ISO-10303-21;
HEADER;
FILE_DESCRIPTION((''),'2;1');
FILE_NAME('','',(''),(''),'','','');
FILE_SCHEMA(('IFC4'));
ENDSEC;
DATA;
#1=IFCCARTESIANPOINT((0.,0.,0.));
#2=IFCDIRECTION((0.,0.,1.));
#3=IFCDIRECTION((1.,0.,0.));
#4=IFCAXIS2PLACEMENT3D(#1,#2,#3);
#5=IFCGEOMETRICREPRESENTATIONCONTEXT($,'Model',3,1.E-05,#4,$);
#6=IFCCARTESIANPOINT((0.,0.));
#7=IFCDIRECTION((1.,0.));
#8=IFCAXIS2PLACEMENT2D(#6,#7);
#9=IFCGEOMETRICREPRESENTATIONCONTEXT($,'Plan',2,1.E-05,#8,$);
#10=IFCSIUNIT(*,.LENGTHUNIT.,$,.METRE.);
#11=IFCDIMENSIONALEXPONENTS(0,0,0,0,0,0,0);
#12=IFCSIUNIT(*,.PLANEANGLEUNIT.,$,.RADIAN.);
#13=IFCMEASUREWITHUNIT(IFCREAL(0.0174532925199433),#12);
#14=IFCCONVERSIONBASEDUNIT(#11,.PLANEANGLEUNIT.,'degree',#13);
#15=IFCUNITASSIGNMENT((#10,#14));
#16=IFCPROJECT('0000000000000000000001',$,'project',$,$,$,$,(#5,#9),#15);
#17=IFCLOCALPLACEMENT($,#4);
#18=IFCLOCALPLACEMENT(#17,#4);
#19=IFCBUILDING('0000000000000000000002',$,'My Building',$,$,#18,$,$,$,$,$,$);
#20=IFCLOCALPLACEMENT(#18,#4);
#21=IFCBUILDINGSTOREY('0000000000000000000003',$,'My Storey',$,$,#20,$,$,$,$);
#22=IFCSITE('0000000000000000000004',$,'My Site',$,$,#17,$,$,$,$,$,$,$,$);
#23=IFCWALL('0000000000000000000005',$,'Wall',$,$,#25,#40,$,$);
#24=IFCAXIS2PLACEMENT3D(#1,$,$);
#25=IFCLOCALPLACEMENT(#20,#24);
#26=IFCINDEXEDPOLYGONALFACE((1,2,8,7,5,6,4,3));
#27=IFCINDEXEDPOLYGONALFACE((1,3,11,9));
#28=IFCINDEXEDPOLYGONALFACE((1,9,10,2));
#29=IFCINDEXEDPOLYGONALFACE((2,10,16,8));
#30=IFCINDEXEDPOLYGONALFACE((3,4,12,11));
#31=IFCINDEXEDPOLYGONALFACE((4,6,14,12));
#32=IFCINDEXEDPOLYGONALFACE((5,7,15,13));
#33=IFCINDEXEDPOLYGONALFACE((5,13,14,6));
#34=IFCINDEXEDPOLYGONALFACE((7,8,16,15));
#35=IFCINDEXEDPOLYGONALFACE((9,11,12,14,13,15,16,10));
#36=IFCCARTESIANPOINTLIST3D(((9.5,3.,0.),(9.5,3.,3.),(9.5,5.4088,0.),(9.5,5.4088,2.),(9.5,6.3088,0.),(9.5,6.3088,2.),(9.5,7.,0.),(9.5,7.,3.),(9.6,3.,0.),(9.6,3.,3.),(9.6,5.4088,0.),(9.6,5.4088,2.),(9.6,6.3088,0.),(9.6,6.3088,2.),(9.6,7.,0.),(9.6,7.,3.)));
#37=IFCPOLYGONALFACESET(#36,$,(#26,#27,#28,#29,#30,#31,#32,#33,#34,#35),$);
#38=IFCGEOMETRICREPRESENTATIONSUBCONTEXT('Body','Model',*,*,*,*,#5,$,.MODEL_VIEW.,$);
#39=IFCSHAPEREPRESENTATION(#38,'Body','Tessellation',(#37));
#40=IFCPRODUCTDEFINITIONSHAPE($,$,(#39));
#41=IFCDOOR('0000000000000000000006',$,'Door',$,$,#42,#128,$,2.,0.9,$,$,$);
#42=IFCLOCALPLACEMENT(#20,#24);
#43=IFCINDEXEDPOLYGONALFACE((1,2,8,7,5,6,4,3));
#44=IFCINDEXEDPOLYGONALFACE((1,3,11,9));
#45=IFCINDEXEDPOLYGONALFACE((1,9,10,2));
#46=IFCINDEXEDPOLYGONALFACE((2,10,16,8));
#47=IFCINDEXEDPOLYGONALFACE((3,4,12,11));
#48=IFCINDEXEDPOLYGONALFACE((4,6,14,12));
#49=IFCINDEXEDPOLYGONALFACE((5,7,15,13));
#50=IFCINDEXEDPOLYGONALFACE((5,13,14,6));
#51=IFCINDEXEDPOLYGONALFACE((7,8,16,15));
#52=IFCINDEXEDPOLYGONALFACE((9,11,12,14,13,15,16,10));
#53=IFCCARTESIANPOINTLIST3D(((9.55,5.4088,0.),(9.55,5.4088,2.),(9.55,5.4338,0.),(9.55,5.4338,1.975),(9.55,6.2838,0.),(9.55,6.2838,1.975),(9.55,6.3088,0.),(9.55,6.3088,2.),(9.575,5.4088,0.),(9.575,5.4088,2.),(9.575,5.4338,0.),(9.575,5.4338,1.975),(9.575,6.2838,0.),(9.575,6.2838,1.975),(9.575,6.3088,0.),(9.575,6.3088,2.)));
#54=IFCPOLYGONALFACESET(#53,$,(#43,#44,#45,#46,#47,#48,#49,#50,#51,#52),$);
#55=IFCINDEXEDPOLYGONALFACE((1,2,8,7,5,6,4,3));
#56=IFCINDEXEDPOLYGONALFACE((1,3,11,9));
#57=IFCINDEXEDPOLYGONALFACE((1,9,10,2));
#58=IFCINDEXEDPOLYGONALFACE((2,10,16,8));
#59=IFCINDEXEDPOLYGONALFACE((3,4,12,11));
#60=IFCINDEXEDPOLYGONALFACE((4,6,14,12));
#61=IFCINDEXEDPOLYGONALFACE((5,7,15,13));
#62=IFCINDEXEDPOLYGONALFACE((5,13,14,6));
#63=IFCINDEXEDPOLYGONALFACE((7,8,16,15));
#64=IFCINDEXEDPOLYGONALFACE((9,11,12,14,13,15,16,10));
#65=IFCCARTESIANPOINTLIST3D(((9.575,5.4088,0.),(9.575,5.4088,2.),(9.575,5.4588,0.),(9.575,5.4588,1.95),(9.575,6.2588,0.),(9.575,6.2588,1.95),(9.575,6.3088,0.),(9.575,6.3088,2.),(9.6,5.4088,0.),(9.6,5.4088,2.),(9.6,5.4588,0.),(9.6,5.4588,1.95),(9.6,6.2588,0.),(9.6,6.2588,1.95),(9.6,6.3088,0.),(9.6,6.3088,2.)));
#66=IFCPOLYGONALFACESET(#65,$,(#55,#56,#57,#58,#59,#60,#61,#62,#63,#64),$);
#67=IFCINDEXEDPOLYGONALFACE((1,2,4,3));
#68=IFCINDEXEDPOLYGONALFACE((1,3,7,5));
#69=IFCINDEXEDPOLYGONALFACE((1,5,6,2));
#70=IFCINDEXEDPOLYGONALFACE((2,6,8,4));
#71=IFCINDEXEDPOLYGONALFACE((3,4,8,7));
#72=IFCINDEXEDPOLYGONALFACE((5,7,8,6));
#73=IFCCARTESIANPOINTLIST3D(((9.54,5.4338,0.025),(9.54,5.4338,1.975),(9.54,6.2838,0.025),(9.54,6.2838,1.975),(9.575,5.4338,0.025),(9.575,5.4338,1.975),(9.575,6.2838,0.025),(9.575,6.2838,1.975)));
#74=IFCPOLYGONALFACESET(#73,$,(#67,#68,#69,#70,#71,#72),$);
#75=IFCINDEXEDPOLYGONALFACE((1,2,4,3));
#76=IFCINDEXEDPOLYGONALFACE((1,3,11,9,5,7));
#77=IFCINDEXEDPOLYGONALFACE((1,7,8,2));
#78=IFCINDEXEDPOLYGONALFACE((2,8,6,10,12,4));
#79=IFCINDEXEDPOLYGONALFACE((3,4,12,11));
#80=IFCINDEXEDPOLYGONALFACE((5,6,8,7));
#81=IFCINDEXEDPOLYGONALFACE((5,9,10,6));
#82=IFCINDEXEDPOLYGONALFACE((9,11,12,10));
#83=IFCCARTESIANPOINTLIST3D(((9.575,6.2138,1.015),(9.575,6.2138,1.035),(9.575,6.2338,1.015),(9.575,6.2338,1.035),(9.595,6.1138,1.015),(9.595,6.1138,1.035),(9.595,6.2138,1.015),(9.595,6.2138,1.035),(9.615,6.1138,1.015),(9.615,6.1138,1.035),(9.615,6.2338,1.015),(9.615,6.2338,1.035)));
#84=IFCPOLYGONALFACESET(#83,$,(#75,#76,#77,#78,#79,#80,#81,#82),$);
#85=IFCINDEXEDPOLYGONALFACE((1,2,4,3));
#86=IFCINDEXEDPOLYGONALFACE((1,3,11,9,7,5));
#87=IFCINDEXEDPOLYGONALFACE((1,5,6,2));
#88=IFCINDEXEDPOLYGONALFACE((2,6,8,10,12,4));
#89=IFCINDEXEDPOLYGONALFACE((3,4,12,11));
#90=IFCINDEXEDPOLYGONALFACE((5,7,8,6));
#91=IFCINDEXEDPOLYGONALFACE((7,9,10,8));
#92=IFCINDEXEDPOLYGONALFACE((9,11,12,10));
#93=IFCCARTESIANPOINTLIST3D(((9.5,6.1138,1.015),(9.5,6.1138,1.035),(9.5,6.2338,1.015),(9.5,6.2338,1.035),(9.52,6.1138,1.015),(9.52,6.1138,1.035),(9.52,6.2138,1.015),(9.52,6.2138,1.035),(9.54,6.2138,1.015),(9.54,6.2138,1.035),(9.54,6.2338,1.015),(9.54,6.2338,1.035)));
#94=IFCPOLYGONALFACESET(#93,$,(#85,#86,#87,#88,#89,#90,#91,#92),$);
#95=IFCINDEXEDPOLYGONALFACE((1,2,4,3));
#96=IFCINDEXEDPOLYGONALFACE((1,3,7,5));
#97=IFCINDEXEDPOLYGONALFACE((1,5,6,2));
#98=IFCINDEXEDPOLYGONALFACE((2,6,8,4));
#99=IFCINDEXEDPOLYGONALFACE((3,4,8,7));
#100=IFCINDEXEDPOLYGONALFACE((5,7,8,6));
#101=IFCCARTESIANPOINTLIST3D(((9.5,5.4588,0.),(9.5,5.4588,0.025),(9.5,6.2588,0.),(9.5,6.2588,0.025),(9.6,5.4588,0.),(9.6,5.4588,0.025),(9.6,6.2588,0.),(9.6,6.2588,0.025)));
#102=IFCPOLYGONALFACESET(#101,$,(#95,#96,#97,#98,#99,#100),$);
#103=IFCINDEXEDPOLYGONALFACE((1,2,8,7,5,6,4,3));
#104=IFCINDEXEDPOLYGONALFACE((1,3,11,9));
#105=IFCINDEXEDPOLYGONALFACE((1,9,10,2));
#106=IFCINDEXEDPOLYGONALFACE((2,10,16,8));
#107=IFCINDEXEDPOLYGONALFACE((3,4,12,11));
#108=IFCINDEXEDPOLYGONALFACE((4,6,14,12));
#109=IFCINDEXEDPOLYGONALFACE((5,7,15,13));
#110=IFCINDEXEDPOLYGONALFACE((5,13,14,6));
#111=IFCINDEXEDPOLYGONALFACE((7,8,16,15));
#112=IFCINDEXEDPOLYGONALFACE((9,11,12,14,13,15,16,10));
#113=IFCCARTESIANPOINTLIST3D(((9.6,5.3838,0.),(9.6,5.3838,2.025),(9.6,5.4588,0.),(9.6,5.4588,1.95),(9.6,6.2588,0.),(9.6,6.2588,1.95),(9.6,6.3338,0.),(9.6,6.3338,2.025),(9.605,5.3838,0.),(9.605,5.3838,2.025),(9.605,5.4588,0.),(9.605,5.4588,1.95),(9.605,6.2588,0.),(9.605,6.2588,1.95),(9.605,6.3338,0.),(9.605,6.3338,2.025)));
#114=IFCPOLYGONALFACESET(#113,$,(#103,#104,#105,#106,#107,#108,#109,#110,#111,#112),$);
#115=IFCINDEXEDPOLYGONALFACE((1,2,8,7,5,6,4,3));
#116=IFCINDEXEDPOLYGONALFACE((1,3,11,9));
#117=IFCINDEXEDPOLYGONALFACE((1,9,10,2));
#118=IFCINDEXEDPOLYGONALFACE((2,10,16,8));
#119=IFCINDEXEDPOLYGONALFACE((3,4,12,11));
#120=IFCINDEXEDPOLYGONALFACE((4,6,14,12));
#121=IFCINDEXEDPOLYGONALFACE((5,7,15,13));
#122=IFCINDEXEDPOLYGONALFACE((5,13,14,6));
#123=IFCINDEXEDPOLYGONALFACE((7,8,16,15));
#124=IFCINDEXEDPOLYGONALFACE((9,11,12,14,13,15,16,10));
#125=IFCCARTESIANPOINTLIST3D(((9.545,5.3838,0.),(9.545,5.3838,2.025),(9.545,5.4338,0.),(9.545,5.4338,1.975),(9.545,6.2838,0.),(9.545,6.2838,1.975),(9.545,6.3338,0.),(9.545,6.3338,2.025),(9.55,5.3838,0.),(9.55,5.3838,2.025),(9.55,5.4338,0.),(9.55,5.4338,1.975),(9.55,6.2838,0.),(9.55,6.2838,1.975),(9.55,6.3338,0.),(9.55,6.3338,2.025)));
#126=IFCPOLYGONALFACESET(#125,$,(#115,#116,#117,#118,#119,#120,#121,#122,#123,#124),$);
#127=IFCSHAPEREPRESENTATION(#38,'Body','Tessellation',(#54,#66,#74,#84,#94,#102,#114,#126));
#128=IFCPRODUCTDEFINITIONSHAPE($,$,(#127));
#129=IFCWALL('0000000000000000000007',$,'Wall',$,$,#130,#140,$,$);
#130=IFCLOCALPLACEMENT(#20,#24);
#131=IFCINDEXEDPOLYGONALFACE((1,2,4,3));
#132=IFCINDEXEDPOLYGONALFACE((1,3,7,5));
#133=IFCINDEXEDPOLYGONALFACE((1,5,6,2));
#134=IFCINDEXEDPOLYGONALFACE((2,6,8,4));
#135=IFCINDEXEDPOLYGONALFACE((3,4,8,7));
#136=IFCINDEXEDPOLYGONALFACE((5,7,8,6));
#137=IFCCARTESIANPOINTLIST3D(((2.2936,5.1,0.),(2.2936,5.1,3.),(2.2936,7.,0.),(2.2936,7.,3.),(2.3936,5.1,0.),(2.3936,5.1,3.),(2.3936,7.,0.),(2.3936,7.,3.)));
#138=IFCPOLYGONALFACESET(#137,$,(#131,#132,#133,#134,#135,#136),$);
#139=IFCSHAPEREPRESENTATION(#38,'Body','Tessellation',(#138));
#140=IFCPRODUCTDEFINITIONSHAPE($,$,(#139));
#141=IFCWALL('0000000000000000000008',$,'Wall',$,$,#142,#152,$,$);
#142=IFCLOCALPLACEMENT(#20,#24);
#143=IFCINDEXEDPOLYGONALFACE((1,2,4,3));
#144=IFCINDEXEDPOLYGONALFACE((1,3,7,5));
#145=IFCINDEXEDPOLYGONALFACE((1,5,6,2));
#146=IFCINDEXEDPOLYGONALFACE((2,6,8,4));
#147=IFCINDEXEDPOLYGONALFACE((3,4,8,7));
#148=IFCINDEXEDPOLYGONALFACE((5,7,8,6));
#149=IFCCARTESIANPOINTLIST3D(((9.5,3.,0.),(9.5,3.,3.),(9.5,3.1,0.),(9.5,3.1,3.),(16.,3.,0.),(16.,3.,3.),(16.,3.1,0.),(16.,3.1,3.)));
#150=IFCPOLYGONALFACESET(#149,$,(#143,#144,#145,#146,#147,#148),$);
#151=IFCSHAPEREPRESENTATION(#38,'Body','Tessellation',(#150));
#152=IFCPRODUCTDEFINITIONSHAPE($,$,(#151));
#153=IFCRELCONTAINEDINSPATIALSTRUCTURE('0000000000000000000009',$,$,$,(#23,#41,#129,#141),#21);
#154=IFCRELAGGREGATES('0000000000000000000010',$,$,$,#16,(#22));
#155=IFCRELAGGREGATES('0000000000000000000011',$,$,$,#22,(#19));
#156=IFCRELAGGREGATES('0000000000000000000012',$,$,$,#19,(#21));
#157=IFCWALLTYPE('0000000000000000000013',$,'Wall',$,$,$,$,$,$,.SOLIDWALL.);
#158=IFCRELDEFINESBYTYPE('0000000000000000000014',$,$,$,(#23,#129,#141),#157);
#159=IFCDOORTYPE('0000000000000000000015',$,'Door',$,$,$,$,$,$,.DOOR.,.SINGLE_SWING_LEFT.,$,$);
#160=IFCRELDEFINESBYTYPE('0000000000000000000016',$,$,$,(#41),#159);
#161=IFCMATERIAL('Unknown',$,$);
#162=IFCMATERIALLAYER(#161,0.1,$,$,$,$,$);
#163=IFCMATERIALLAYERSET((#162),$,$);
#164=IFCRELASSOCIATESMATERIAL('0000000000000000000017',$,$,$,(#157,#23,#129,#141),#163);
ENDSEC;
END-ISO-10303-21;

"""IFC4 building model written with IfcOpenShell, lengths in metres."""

from ifc_helpers import new_model, entity, si_unit, converted_unit, frame, origin_with_axes, origin_2d_with_axis, place, context, subcontext, project, spatial, line, indexed_curve, outline, extrude, shape, source, transform, mapped, material, layer, layer_set, layer_usage, type_object, type_shapes, element, fill, save


model = new_model("IFC4")

# Units and contexts
model_context = context("Model", 3, precision=1e-05, world=origin_with_axes())
plan_context = context("Plan", 2, precision=1e-05, world=origin_2d_with_axis())
body_context_1 = subcontext(model_context, "Body", "Model", "MODEL_VIEW")
body_context_2 = subcontext(plan_context, "Body", "Plan", "PLAN_VIEW")
ifc_project = project(units=[si_unit("LENGTHUNIT", "METRE"), converted_unit("PLANEANGLEUNIT", "degree", entity("IfcReal", 0.0174532925199433), si_unit("PLANEANGLEUNIT", "RADIAN"), dimensions=[0, 0, 0, 0, 0, 0, 0])], contexts=[model_context, plan_context])

# Site, building, storey
site_placement = place(None, origin_with_axes())
site = spatial("IfcSite", under=ifc_project, at=site_placement, Name="My Site")
building_placement = place(site_placement, origin_with_axes())
building = spatial("IfcBuilding", under=site, at=building_placement, Name="My Building")
storey_placement = place(building_placement, origin_with_axes())
storey = spatial("IfcBuildingStorey", under=building, at=storey_placement, Name="My Storey")

# Shared definitions
ifc_material = material(Name="Unknown")

# Shared definitions
ifc_layer_1 = layer(ifc_material, 0.1)
ifc_layer_set_1 = layer_set([ifc_layer_1])
wall_type = type_object("IfcWallType", Name="Wall", PredefinedType="SOLIDWALL", material=ifc_layer_set_1)
shared_shape_1 = source(origin_with_axes(), body_context_1, "Body", "SweptSolid", [
    extrude(outline(indexed_curve([(0.0, 0.0), (0.9, 0.0), (0.9, 2.0), (0.0, 2.0)], segments=[line(1, 2, 3, 4, 1)])), frame((0.0, -0.6, 0.0), z_axis=(0.0, -1.0, 0.0), x_axis=(1.0, 0.0, 0.0)), (0.0, 0.0, -1.0), 1.2),
])
door_type = type_object("IfcDoorType", Name="Door", OperationType="SINGLE_SWING_LEFT", PredefinedType="DOOR")
shared_shape_2 = source(origin_with_axes(), body_context_1, "Body", "SweptSolid", [
    extrude(outline(indexed_curve([(0.0, 0.0), (0.0, 2.0), (0.9, 2.0), (0.9, 0.0), (0.875, 0.0), (0.875, 1.975), (0.025, 1.975), (0.025, 0.0)], segments=[line(1, 2, 3, 4, 5, 6, 7, 8, 1)])), frame((0.0, 0.025, 0.0), z_axis=(0.0, -1.0, 0.0), x_axis=(1.0, 0.0, 0.0)), (0.0, 0.0, -1.0), 0.025),
    extrude(outline(indexed_curve([(0.0, 0.0), (0.0, 2.0), (0.9, 2.0), (0.9, 0.0), (0.85, 0.0), (0.85, 1.95), (0.05, 1.95), (0.05, 0.0)], segments=[line(1, 2, 3, 4, 5, 6, 7, 8, 1)])), frame((0.0, 0.0, 0.0), z_axis=(0.0, -1.0, 0.0), x_axis=(1.0, 0.0, 0.0)), (0.0, 0.0, -1.0), 0.025),
    extrude(outline(indexed_curve([(0.0, 0.0), (0.85, 0.0), (0.85, 0.035), (0.0, 0.035)], segments=[line(1, 2, 3, 4, 1)])), frame((0.025, 0.025, 0.025), z_axis=(0.0, 0.0, 1.0), x_axis=(1.0, 0.0, 0.0)), (0.0, 0.0, 1.0), 1.95),
    extrude(outline(indexed_curve([(0.0, 0.0), (0.0, -0.04), (-0.12, -0.04), (-0.12, -0.02), (-0.02, -0.02), (-0.02, 0.0)], segments=[line(1, 2, 3, 4, 5, 6, 1)])), frame((0.825, 0.025, 1.015), z_axis=(0.0, 0.0, 1.0), x_axis=(1.0, 0.0, 0.0)), (0.0, 0.0, 1.0), 0.02),
    extrude(outline(indexed_curve([(0.0, 0.0), (0.0, 0.04), (-0.12, 0.04), (-0.12, 0.02), (-0.02, 0.02), (-0.02, 0.0)], segments=[line(1, 2, 3, 4, 5, 6, 1)])), frame((0.825, 0.06, 1.015), z_axis=(0.0, 0.0, 1.0), x_axis=(1.0, 0.0, 0.0)), (0.0, 0.0, 1.0), 0.02),
    extrude(outline(indexed_curve([(0.0, 0.0), (0.8, 0.0), (0.8, 0.1), (0.0, 0.1)], segments=[line(1, 2, 3, 4, 1)])), frame((0.05, 0.0, 0.0), z_axis=(0.0, 0.0, 1.0), x_axis=(1.0, 0.0, 0.0)), (0.0, 0.0, 1.0), 0.025),
    extrude(outline(indexed_curve([(0.0, 0.0), (0.0, 2.025), (0.95, 2.025), (0.95, 0.0), (0.875, 0.0), (0.875, 1.95), (0.075, 1.95), (0.075, 0.0)], segments=[line(1, 2, 3, 4, 5, 6, 7, 8, 1)])), frame((-0.025, -0.005, 0.0), z_axis=(0.0, -1.0, 0.0), x_axis=(1.0, 0.0, 0.0)), (0.0, 0.0, -1.0), 0.005),
    extrude(outline(indexed_curve([(0.0, 0.0), (0.0, 2.025), (0.95, 2.025), (0.95, 0.0), (0.9, 0.0), (0.9, 1.975), (0.05, 1.975), (0.05, 0.0)], segments=[line(1, 2, 3, 4, 5, 6, 7, 8, 1)])), frame((-0.025, 0.05, 0.0), z_axis=(0.0, -1.0, 0.0), x_axis=(1.0, 0.0, 0.0)), (0.0, 0.0, -1.0), 0.005),
])
shared_shape_3 = source(origin_with_axes(), body_context_2, "Body", "Curve2D", [
    entity("IfcIndexedPolyCurve", entity("IfcCartesianPointList2D", [[0.0, 0.0], [0.0, 0.05], [0.025, 0.05], [0.025, 0.025], [0.05, 0.025], [0.05, 0.0]]), [entity("IfcLineIndex", [1, 2, 3, 4, 5, 6, 1])]),
    entity("IfcIndexedPolyCurve", entity("IfcCartesianPointList2D", [[0.9, 0.0], [0.9, 0.05], [0.875, 0.05], [0.875, 0.025], [0.85, 0.025], [0.85, 0.0]]), [entity("IfcLineIndex", [1, 2, 3, 4, 5, 6, 1])]),
    entity("IfcTrimmedCurve", entity("IfcEllipse", entity("IfcAxis2Placement2D", entity("IfcCartesianPoint", [0.06, 0.05]), entity("IfcDirection", [1.0, 0.0])), 0.815, 0.85), [entity("IfcCartesianPoint", [0.875, 0.05])], [entity("IfcCartesianPoint", [0.06, 0.9])], True, "CARTESIAN"),
    entity("IfcIndexedPolyCurve", entity("IfcCartesianPointList2D", [[0.025, 0.05], [0.06, 0.05], [0.06, 0.9], [0.025, 0.9]]), [entity("IfcLineIndex", [1, 2, 3, 4, 1])]),
])
type_shapes(door_type, [shared_shape_2, shared_shape_3])

# Wall, opening, door
ifc_layer_usage_1 = layer_usage(ifc_layer_set_1, "AXIS2", "POSITIVE", 0.0)
wall_1_placement = place(storey_placement, frame((9.6, 3.0, 0.0), z_axis=(0.0, 0.0, 1.0), x_axis=(0.0, 1.0, 0.0)))
wall_1 = element("IfcWall", 1, at=wall_1_placement, inside=storey, type_object=wall_type, material=ifc_layer_usage_1, Name="Wall", context=body_context_1, shape_type="SweptSolid", body=[
    extrude(outline(indexed_curve([(0.0, 0.0), (0.0, 0.1), (4.0, 0.1), (4.0, 0.0)], segments=[line(1, 2, 3, 4, 1)])), origin_with_axes(), (0.0, 0.0, 1.0), 3.0),
])
opening_1_placement = place(wall_1_placement, frame((2.4088, 0.0, 0.0), z_axis=(0.0, 0.0, 1.0), x_axis=(1.0, 0.0, 0.0)))
opening_1 = element("IfcOpeningElement", 2, at=opening_1_placement, cuts=wall_1, PredefinedType="OPENING", context=body_context_1, shape_type="MappedRepresentation", body=[
    mapped(shared_shape_1, transform((0.0, 0.0, 0.0), x_axis=(1.0, 0.0, 0.0), y_axis=(0.0, 1.0, 0.0), z_axis=(0.0, 0.0, 1.0), scale=1.0)),
])
door_1_placement = place(opening_1_placement, frame((0.0, 0.0, 0.0), z_axis=(0.0, 0.0, 1.0), x_axis=(1.0, 0.0, 0.0)))
door_1 = element("IfcDoor", 3, at=door_1_placement, inside=storey, type_object=door_type, Name="Door", OverallHeight=2.0, OverallWidth=0.9, shapes=[
    shape(body_context_1, "Body", "MappedRepresentation", [mapped(shared_shape_2, transform((0.0, 0.0, 0.0), x_axis=(1.0, 0.0, 0.0), y_axis=(0.0, 1.0, 0.0), z_axis=(0.0, 0.0, 1.0), scale=1.0))]),
    shape(body_context_2, "Body", "MappedRepresentation", [mapped(shared_shape_3, transform((0.0, 0.0, 0.0), x_axis=(1.0, 0.0, 0.0), y_axis=(0.0, 1.0, 0.0), z_axis=(0.0, 0.0, 1.0), scale=1.0))]),
])
fill(opening_1, door_1)

# Walls
ifc_layer_usage_2 = layer_usage(ifc_layer_set_1, "AXIS2", "POSITIVE", 0.0)
wall_2_placement = place(storey_placement, frame((2.2936, 7.0, 0.0), z_axis=(0.0, 0.0, 1.0), x_axis=(0.0, -1.0, 0.0)))
element("IfcWall", 4, at=wall_2_placement, inside=storey, type_object=wall_type, material=ifc_layer_usage_2, Name="Wall", context=body_context_1, shape_type="SweptSolid", body=[
    extrude(outline(indexed_curve([(0.0, 0.0), (0.0, 0.1), (1.9, 0.1), (1.9, 0.0)], segments=[line(1, 2, 3, 4, 1)])), origin_with_axes(), (0.0, 0.0, 1.0), 3.0),
])
ifc_layer_usage_3 = layer_usage(ifc_layer_set_1, "AXIS2", "POSITIVE", 0.0)
wall_3_placement = place(storey_placement, frame((9.5, 3.0, 0.0), z_axis=(0.0, 0.0, 1.0), x_axis=(1.0, 0.0, 0.0)))
element("IfcWall", 5, at=wall_3_placement, inside=storey, type_object=wall_type, material=ifc_layer_usage_3, Name="Wall", context=body_context_1, shape_type="SweptSolid", body=[
    extrude(outline(indexed_curve([(0.0, 0.0), (0.0, 0.1), (6.5, 0.1), (6.5, 0.0)], segments=[line(1, 2, 3, 4, 1)])), origin_with_axes(), (0.0, 0.0, 1.0), 3.0),
])

save(model, "model.ifc")
